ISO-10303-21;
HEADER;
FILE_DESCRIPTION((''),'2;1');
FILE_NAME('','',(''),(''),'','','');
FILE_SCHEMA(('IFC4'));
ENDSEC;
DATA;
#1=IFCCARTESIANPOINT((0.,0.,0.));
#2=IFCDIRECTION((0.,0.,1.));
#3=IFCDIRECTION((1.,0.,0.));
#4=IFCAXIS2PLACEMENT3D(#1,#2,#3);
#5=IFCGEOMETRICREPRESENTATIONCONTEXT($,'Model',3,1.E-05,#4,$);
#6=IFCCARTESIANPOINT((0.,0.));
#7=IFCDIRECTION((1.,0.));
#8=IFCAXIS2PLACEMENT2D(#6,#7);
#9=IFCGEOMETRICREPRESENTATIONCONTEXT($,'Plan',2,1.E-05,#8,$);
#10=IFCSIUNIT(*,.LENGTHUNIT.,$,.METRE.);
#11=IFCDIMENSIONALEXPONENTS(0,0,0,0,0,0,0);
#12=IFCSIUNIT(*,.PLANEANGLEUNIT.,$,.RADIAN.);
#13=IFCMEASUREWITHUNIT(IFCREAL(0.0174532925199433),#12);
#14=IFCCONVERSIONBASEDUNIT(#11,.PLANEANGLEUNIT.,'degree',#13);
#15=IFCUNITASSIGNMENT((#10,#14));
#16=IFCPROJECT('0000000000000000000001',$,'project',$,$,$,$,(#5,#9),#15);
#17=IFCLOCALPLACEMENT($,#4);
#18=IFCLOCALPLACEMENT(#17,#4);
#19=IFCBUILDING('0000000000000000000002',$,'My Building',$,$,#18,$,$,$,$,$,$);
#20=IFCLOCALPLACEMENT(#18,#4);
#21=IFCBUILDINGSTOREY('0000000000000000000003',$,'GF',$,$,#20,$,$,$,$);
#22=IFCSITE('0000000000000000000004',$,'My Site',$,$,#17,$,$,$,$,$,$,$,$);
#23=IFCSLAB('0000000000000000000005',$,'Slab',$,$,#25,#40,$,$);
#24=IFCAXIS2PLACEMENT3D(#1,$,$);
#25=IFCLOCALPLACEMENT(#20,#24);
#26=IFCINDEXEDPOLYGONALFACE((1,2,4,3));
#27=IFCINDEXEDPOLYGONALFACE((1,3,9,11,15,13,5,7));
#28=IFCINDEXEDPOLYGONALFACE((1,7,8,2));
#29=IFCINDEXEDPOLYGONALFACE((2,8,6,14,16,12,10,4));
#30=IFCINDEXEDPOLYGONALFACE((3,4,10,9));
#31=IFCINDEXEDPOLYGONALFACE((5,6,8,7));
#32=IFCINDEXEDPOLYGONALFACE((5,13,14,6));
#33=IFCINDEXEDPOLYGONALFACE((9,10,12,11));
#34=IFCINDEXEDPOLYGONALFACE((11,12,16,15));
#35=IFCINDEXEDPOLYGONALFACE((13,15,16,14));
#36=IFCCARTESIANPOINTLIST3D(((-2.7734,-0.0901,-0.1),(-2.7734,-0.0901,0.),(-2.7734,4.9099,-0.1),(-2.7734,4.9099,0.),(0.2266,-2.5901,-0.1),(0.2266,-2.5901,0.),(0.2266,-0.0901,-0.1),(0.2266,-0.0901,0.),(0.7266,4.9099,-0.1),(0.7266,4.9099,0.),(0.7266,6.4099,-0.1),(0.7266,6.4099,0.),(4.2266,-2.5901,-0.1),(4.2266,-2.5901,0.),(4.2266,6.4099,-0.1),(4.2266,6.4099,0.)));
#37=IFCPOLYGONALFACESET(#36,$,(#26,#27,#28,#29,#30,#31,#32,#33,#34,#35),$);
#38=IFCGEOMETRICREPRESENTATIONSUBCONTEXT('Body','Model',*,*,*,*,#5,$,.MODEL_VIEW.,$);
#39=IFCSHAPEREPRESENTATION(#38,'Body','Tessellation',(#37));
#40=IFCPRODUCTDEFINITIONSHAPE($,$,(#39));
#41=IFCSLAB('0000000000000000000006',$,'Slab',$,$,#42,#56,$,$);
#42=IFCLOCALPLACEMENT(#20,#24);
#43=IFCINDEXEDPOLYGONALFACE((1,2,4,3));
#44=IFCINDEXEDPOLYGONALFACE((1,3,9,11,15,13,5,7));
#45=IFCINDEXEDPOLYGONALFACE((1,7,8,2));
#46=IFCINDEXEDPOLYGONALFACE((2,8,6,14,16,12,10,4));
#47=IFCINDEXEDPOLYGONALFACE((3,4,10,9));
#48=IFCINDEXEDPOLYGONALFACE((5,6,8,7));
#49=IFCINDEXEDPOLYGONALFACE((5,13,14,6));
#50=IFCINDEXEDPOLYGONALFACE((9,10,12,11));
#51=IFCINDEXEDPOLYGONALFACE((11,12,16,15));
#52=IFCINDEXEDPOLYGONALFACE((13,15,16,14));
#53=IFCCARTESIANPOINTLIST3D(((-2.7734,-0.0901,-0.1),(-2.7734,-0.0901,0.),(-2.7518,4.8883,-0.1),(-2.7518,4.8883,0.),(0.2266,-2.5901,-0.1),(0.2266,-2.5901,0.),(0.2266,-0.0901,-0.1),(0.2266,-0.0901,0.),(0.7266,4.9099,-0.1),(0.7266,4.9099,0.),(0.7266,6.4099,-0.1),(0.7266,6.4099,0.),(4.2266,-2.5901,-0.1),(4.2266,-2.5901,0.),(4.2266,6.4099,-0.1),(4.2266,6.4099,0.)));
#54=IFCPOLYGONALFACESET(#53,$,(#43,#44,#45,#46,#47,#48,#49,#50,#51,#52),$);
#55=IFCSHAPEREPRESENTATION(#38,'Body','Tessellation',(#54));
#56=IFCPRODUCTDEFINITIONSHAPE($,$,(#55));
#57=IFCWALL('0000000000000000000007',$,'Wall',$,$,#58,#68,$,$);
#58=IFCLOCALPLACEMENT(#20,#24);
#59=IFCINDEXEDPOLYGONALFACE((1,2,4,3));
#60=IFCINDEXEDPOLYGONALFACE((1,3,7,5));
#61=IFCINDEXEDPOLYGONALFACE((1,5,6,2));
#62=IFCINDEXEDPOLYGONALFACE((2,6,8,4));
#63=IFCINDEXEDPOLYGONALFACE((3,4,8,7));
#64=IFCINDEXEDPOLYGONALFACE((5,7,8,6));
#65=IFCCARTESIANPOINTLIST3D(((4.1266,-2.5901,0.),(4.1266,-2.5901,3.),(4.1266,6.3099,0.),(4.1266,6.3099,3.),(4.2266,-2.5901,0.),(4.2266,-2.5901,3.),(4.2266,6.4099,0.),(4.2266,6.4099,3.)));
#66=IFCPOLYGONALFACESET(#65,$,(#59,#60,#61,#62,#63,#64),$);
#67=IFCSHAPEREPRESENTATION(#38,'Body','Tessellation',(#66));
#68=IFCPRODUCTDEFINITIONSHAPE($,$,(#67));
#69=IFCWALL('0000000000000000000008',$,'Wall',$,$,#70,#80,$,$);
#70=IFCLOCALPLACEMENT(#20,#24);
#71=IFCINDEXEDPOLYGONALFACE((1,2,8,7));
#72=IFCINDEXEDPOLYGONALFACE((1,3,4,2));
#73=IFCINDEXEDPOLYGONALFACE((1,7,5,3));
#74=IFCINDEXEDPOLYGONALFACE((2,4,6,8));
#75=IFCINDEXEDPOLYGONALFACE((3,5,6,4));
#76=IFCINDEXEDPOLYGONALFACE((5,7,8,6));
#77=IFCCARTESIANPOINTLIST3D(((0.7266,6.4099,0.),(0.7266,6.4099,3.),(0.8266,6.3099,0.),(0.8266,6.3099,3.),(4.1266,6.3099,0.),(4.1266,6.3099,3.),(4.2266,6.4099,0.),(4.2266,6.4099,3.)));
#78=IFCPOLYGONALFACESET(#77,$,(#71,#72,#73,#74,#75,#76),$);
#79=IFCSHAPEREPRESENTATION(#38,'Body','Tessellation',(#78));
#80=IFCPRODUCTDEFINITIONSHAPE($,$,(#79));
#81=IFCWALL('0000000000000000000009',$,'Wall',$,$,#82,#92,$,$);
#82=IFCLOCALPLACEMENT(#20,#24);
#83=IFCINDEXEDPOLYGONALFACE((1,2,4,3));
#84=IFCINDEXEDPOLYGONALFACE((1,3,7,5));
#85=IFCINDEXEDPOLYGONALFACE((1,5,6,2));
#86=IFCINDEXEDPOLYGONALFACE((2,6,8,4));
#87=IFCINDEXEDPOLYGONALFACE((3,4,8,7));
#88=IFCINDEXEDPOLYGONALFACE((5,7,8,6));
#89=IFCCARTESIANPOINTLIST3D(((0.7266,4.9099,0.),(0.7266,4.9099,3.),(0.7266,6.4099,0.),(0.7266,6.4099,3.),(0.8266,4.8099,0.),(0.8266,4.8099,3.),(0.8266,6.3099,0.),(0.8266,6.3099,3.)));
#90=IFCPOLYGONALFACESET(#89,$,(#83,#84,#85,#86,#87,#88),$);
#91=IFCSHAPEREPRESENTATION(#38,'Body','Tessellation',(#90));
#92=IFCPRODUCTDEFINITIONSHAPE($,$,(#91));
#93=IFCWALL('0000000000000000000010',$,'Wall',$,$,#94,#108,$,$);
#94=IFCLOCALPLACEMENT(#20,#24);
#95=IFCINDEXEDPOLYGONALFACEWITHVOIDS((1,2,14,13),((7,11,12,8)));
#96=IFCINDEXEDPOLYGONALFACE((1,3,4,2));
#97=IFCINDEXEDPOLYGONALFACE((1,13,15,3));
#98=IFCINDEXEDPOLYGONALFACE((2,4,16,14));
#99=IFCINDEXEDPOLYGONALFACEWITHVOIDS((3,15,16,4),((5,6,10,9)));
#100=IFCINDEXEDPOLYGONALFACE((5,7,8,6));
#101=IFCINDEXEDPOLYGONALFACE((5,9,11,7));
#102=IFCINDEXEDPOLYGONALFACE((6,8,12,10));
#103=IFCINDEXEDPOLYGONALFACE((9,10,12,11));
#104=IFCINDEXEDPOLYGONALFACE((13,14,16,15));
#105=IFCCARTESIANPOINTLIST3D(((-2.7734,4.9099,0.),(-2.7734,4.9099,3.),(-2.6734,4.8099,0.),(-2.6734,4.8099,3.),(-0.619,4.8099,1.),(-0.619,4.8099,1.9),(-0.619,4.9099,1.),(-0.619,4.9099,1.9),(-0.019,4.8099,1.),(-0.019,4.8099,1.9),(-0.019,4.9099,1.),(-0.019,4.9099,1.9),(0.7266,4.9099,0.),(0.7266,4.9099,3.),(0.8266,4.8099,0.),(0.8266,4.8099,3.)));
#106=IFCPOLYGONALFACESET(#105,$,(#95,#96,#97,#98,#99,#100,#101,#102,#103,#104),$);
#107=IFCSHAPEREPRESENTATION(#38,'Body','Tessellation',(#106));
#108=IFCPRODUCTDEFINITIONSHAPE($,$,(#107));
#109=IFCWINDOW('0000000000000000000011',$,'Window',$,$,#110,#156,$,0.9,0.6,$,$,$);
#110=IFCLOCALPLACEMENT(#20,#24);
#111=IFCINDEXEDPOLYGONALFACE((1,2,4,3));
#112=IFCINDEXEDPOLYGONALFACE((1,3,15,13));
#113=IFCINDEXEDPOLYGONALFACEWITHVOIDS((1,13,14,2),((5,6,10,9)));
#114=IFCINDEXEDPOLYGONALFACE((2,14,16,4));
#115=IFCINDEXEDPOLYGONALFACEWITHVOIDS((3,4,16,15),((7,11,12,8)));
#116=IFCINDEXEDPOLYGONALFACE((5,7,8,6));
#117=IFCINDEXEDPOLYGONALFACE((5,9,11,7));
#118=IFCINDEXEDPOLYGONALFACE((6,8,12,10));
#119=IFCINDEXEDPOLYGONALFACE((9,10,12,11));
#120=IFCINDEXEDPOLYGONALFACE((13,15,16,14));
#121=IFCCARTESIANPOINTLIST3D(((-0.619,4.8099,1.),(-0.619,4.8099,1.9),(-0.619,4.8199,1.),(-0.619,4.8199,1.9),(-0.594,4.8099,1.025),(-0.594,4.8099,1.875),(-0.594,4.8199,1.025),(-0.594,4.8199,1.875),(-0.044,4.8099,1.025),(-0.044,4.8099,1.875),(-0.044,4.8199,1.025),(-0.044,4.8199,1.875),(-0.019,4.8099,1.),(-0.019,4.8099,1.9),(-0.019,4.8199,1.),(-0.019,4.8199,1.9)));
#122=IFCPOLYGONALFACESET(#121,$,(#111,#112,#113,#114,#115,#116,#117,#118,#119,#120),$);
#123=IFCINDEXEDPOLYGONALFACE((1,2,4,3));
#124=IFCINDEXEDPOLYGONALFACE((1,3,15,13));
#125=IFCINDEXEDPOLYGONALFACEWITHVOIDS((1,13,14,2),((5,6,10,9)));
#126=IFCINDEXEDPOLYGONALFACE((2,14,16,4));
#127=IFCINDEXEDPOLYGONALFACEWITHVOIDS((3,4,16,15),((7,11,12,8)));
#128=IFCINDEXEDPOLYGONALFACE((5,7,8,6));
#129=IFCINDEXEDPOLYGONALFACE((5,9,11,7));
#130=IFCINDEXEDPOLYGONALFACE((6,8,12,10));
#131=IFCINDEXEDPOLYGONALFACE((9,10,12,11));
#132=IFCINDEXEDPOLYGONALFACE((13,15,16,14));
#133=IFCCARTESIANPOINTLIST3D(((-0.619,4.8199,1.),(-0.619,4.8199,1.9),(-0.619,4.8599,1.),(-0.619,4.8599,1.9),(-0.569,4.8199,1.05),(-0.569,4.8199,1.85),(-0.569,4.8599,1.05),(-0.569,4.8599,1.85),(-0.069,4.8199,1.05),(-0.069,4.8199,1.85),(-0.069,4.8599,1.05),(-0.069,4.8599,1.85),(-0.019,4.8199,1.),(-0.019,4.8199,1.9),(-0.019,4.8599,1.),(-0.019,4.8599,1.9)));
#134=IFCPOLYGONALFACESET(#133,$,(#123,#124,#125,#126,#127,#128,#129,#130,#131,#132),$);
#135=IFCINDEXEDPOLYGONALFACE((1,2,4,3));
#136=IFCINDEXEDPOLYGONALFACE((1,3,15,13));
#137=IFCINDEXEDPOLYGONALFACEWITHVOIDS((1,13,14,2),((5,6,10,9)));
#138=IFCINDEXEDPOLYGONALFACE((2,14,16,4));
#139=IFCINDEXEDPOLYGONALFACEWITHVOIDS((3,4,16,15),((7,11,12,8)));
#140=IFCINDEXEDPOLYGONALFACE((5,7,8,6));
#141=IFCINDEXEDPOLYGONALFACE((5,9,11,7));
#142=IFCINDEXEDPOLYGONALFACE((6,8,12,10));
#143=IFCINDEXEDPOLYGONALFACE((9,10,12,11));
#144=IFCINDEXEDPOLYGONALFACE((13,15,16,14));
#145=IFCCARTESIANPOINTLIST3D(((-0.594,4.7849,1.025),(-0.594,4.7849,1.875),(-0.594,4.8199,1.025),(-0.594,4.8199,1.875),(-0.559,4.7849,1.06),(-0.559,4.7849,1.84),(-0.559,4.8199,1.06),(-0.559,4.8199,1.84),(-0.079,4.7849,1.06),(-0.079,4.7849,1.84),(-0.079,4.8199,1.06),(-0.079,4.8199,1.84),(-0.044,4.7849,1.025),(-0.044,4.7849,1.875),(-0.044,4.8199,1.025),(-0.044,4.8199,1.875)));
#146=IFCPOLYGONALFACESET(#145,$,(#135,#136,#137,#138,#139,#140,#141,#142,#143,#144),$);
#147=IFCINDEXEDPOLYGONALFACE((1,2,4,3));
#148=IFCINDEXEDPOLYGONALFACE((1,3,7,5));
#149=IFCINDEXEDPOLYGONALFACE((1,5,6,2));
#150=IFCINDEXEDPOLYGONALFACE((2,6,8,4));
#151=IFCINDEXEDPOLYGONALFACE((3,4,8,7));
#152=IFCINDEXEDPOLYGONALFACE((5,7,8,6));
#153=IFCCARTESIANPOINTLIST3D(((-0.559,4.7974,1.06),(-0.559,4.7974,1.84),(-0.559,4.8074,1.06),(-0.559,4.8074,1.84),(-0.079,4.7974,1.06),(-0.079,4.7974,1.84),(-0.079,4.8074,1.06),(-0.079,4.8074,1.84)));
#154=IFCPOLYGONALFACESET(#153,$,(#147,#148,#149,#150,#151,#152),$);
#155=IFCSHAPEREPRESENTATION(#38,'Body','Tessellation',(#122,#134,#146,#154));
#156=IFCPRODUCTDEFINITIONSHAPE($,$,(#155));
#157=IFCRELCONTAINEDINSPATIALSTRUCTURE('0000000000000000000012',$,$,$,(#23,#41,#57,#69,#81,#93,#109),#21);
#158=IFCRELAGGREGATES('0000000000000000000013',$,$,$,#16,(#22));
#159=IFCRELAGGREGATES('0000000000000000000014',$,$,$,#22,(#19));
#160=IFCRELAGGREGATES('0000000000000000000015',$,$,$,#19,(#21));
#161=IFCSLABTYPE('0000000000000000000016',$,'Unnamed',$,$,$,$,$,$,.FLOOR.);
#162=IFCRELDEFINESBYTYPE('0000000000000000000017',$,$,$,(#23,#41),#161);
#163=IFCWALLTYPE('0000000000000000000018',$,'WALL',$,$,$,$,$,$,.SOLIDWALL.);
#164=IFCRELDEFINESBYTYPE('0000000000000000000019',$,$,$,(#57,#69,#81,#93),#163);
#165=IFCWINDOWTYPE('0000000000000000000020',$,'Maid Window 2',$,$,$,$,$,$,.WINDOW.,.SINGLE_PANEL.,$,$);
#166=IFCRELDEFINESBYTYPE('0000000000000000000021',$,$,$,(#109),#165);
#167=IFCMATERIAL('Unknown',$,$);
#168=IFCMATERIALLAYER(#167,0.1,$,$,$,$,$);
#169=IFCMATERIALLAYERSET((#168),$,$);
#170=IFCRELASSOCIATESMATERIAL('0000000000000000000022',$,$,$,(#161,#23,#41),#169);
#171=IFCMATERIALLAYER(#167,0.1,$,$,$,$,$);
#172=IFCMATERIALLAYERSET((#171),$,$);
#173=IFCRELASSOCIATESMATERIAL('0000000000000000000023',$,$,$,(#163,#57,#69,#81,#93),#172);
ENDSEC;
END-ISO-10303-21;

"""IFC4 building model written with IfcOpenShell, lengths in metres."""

from ifc_helpers import new_model, entity, si_unit, converted_unit, frame, origin_with_axes, origin_2d_with_axis, place, context, subcontext, project, spatial, line, indexed_curve, outline, extrude, shape, source, transform, mapped, material, layer, layer_set, layer_usage, type_object, type_shapes, element, fill, save


model = new_model("IFC4")

# Units and contexts
model_context = context("Model", 3, precision=1e-05, world=origin_with_axes())
plan_context = context("Plan", 2, precision=1e-05, world=origin_2d_with_axis())
body_context_1 = subcontext(model_context, "Body", "Model", "MODEL_VIEW")
body_context_2 = subcontext(plan_context, "Body", "Plan", "PLAN_VIEW")
ifc_project = project(units=[si_unit("LENGTHUNIT", "METRE"), converted_unit("PLANEANGLEUNIT", "degree", entity("IfcReal", 0.0174532925199433), si_unit("PLANEANGLEUNIT", "RADIAN"), dimensions=[0, 0, 0, 0, 0, 0, 0])], contexts=[model_context, plan_context])

# Site, building, storey
site_placement = place(None, origin_with_axes())
site = spatial("IfcSite", under=ifc_project, at=site_placement, Name="My Site")
building_placement = place(site_placement, origin_with_axes())
building = spatial("IfcBuilding", under=site, at=building_placement, Name="My Building")
storey_placement = place(building_placement, origin_with_axes())
storey = spatial("IfcBuildingStorey", under=building, at=storey_placement, Name="GF")

# Slabs
ifc_material_1 = material(Name="Unknown")
ifc_layer_1 = layer(ifc_material_1, 0.1)
ifc_layer_set_1 = layer_set([ifc_layer_1])
ifc_layer_usage_1 = layer_usage(ifc_layer_set_1, "AXIS3", "POSITIVE", -0.1)
slab_type = type_object("IfcSlabType", Name="Unnamed", PredefinedType="FLOOR", material=ifc_layer_set_1)
slab_1_placement = place(storey_placement, frame((4.2266, -2.5901, 0.0), z_axis=(0.0, 0.0, 1.0), x_axis=(1.0, 0.0, 0.0)))
element("IfcSlab", 1, at=slab_1_placement, inside=storey, type_object=slab_type, material=ifc_layer_usage_1, Name="Slab", context=body_context_1, shape_type="SweptSolid", body=[
    extrude(outline(indexed_curve([(0.0, 0.0), (0.0, 9.0), (-3.5, 9.0), (-3.5, 7.5), (-7.0, 7.5), (-7.0, 2.5), (-4.0, 2.5), (-4.0, 0.0), (0.0, 0.0)])), frame((0.0, 0.0, -0.1), z_axis=(0.0, 0.0, 1.0), x_axis=(1.0, 0.0, 0.0)), (0.0, 0.0, 1.0), 0.1),
])
ifc_layer_usage_2 = layer_usage(ifc_layer_set_1, "AXIS3", "POSITIVE", -0.1)
slab_2_placement = place(storey_placement, frame((0.7266, 6.4099, 0.0), z_axis=(0.0, 0.0, 1.0), x_axis=(1.0, 0.0, 0.0)))
element("IfcSlab", 2, at=slab_2_placement, inside=storey, type_object=slab_type, material=ifc_layer_usage_2, Name="Slab", context=body_context_1, shape_type="SweptSolid", body=[
    extrude(outline(indexed_curve([(0.0, 0.0), (3.5, 0.0), (3.5, -9.0), (-0.5, -9.0), (-0.5, -6.5), (-3.5, -6.5), (-3.4784, -1.5216), (0.0, -1.5), (0.0, 0.0)])), frame((0.0, 0.0, -0.1), z_axis=(0.0, 0.0, 1.0), x_axis=(1.0, 0.0, 0.0)), (0.0, 0.0, 1.0), 0.1),
])

# Walls
ifc_layer_2 = layer(ifc_material_1, 0.1)
ifc_layer_set_2 = layer_set([ifc_layer_2])
ifc_layer_usage_3 = layer_usage(ifc_layer_set_2, "AXIS2", "POSITIVE", 0.0)
wall_type = type_object("IfcWallType", Name="WALL", PredefinedType="SOLIDWALL", material=ifc_layer_set_2)
wall_1_placement = place(storey_placement, frame((4.2266, -2.5901, 0.0), z_axis=(0.0, 0.0, 1.0), x_axis=(0.0, 1.0, 0.0)))
element("IfcWall", 3, at=wall_1_placement, inside=storey, type_object=wall_type, material=ifc_layer_usage_3, Name="Wall", context=body_context_1, shape_type="SweptSolid", body=[
    extrude(outline(indexed_curve([(0.0, 0.0), (0.0, 0.1), (8.9, 0.1), (9.0, 0.0)], segments=[line(1, 2, 3, 4, 1)])), origin_with_axes(), (0.0, 0.0, 1.0), 3.0),
])
ifc_layer_usage_4 = layer_usage(ifc_layer_set_2, "AXIS2", "POSITIVE", 0.0)
wall_2_placement = place(storey_placement, frame((4.2266, 6.4099, 0.0), z_axis=(0.0, 0.0, 1.0), x_axis=(-1.0, 0.0, 0.0)))
element("IfcWall", 4, at=wall_2_placement, inside=storey, type_object=wall_type, material=ifc_layer_usage_4, Name="Wall", context=body_context_1, shape_type="SweptSolid", body=[
    extrude(outline(indexed_curve([(0.0, 0.0), (0.1, 0.1), (3.4, 0.1), (3.5, 0.0)], segments=[line(1, 2, 3, 4, 1)])), origin_with_axes(), (0.0, 0.0, 1.0), 3.0),
])
ifc_layer_usage_5 = layer_usage(ifc_layer_set_2, "AXIS2", "POSITIVE", 0.0)
wall_3_placement = place(storey_placement, frame((0.7266, 6.4099, 0.0), z_axis=(0.0, 0.0, 1.0), x_axis=(0.0, -1.0, 0.0)))
element("IfcWall", 5, at=wall_3_placement, inside=storey, type_object=wall_type, material=ifc_layer_usage_5, Name="Wall", context=body_context_1, shape_type="SweptSolid", body=[
    extrude(outline(indexed_curve([(0.0, 0.0), (0.1, 0.1), (1.6, 0.1), (1.5, 0.0)], segments=[line(1, 2, 3, 4, 1)])), origin_with_axes(), (0.0, 0.0, 1.0), 3.0),
])

# Wall, opening, window
ifc_layer_usage_6 = layer_usage(ifc_layer_set_2, "AXIS2", "POSITIVE", 0.0)
wall_4_placement = place(storey_placement, frame((0.7266, 4.9099, 0.0), z_axis=(0.0, 0.0, 1.0), x_axis=(-1.0, 0.0, 0.0)))
wall_4 = element("IfcWall", 6, at=wall_4_placement, inside=storey, type_object=wall_type, material=ifc_layer_usage_6, Name="Wall", context=body_context_1, shape_type="SweptSolid", body=[
    extrude(outline(indexed_curve([(0.0, 0.0), (-0.1, 0.1), (3.4, 0.1), (3.5, 0.0)], segments=[line(1, 2, 3, 4, 1)])), origin_with_axes(), (0.0, 0.0, 1.0), 3.0),
])
shared_shape_1 = source(origin_with_axes(), body_context_1, "Body", "SweptSolid", [
    extrude(outline(indexed_curve([(0.0, 0.0), (0.6, 0.0), (0.6, 0.9), (0.0, 0.9)], segments=[line(1, 2, 3, 4, 1)])), frame((0.0, -0.6, 0.0), z_axis=(0.0, -1.0, 0.0), x_axis=(1.0, 0.0, 0.0)), (0.0, 0.0, -1.0), 1.2),
])
opening_1_placement = place(wall_4_placement, frame((0.7456, 0.0, 1.0), z_axis=(0.0, 0.0, 1.0), x_axis=(1.0, 0.0, 0.0)))
opening_1 = element("IfcOpeningElement", 7, at=opening_1_placement, cuts=wall_4, PredefinedType="OPENING", context=body_context_1, shape_type="MappedRepresentation", body=[
    mapped(shared_shape_1, transform((0.0, 0.0, 0.0), x_axis=(1.0, 0.0, 0.0), y_axis=(0.0, 1.0, 0.0), z_axis=(0.0, 0.0, 1.0), scale=1.0)),
])
window_type_1 = type_object("IfcWindowType", Name="Maid Window 2", PartitioningType="SINGLE_PANEL", PredefinedType="WINDOW")
shared_shape_2 = source(origin_with_axes(), body_context_1, "Body", "SweptSolid", [
    extrude(outline(indexed_curve([(0.0, 0.0), (0.6, 0.0), (0.6, 0.9), (0.0, 0.9)], segments=[line(1, 2, 3, 4, 1)]), holes=[indexed_curve([(0.025, 0.025), (0.575, 0.025), (0.575, 0.875), (0.025, 0.875)], segments=[line(1, 2, 3, 4, 1)])]), frame((0.0, 0.09, 0.0), z_axis=(0.0, -1.0, 0.0), x_axis=(1.0, 0.0, 0.0)), (0.0, 0.0, -1.0), 0.01),
    extrude(outline(indexed_curve([(0.0, 0.0), (0.6, 0.0), (0.6, 0.9), (0.0, 0.9)], segments=[line(1, 2, 3, 4, 1)]), holes=[indexed_curve([(0.05, 0.05), (0.55, 0.05), (0.55, 0.85), (0.05, 0.85)], segments=[line(1, 2, 3, 4, 1)])]), frame((0.0, 0.05, 0.0), z_axis=(0.0, -1.0, 0.0), x_axis=(1.0, 0.0, 0.0)), (0.0, 0.0, -1.0), 0.04),
    extrude(outline(indexed_curve([(0.0, 0.0), (0.55, 0.0), (0.55, 0.85), (0.0, 0.85)], segments=[line(1, 2, 3, 4, 1)]), holes=[indexed_curve([(0.035, 0.035), (0.515, 0.035), (0.515, 0.815), (0.035, 0.815)], segments=[line(1, 2, 3, 4, 1)])]), frame((0.025, 0.09, 0.025), z_axis=(0.0, -1.0, 0.0), x_axis=(1.0, 0.0, 0.0)), (0.0, 0.0, -1.0), 0.035),
    extrude(outline(indexed_curve([(0.035, 0.035), (0.515, 0.035), (0.515, 0.815), (0.035, 0.815)], segments=[line(1, 2, 3, 4, 1)])), frame((0.025, 0.1025, 0.025), z_axis=(0.0, -1.0, 0.0), x_axis=(1.0, 0.0, 0.0)), (0.0, 0.0, -1.0), 0.01),
])
shared_shape_3 = source(origin_with_axes(), body_context_2, "Body", "Curve2D", [
    entity("IfcIndexedPolyCurve", entity("IfcCartesianPointList2D", [[0.05, 0.05], [0.55, 0.05]])),
    entity("IfcIndexedPolyCurve", entity("IfcCartesianPointList2D", [[0.0, 0.1], [0.025, 0.1], [0.025, 0.09], [0.05, 0.09], [0.05, 0.05], [0.0, 0.05]]), [entity("IfcLineIndex", [1, 2, 3, 4, 5, 6, 1])]),
    entity("IfcIndexedPolyCurve", entity("IfcCartesianPointList2D", [[0.6, 0.1], [0.575, 0.1], [0.575, 0.09], [0.55, 0.09], [0.55, 0.05], [0.6, 0.05]]), [entity("IfcLineIndex", [1, 2, 3, 4, 5, 6, 1])]),
    entity("IfcIndexedPolyCurve", entity("IfcCartesianPointList2D", [[0.025, 0.09], [0.06, 0.09], [0.06, 0.125], [0.025, 0.125]]), [entity("IfcLineIndex", [1, 2, 3, 4, 1])]),
    entity("IfcIndexedPolyCurve", entity("IfcCartesianPointList2D", [[0.575, 0.09], [0.54, 0.09], [0.54, 0.125], [0.575, 0.125]]), [entity("IfcLineIndex", [1, 2, 3, 4, 1])]),
    entity("IfcIndexedPolyCurve", entity("IfcCartesianPointList2D", [[0.06, 0.09], [0.54, 0.09]])),
    entity("IfcIndexedPolyCurve", entity("IfcCartesianPointList2D", [[0.06, 0.125], [0.54, 0.125]])),
    entity("IfcIndexedPolyCurve", entity("IfcCartesianPointList2D", [[0.06, 0.1075], [0.54, 0.1075]])),
])
type_shapes(window_type_1, [shared_shape_2, shared_shape_3])
window_1_placement = place(opening_1_placement, frame((0.0, 0.0, 0.0), z_axis=(0.0, 0.0, 1.0), x_axis=(1.0, 0.0, 0.0)))
window_1 = element("IfcWindow", 8, at=window_1_placement, inside=storey, type_object=window_type_1, Name="Window", OverallHeight=0.9, OverallWidth=0.6, shapes=[
    shape(body_context_1, "Body", "MappedRepresentation", [mapped(shared_shape_2, transform((0.0, 0.0, 0.0), x_axis=(1.0, 0.0, 0.0), y_axis=(0.0, 1.0, 0.0), z_axis=(0.0, 0.0, 1.0), scale=1.0))]),
    shape(body_context_2, "Body", "MappedRepresentation", [mapped(shared_shape_3, transform((0.0, 0.0, 0.0), x_axis=(1.0, 0.0, 0.0), y_axis=(0.0, 1.0, 0.0), z_axis=(0.0, 0.0, 1.0), scale=1.0))]),
])
fill(opening_1, window_1)

save(model, "model.ifc")
